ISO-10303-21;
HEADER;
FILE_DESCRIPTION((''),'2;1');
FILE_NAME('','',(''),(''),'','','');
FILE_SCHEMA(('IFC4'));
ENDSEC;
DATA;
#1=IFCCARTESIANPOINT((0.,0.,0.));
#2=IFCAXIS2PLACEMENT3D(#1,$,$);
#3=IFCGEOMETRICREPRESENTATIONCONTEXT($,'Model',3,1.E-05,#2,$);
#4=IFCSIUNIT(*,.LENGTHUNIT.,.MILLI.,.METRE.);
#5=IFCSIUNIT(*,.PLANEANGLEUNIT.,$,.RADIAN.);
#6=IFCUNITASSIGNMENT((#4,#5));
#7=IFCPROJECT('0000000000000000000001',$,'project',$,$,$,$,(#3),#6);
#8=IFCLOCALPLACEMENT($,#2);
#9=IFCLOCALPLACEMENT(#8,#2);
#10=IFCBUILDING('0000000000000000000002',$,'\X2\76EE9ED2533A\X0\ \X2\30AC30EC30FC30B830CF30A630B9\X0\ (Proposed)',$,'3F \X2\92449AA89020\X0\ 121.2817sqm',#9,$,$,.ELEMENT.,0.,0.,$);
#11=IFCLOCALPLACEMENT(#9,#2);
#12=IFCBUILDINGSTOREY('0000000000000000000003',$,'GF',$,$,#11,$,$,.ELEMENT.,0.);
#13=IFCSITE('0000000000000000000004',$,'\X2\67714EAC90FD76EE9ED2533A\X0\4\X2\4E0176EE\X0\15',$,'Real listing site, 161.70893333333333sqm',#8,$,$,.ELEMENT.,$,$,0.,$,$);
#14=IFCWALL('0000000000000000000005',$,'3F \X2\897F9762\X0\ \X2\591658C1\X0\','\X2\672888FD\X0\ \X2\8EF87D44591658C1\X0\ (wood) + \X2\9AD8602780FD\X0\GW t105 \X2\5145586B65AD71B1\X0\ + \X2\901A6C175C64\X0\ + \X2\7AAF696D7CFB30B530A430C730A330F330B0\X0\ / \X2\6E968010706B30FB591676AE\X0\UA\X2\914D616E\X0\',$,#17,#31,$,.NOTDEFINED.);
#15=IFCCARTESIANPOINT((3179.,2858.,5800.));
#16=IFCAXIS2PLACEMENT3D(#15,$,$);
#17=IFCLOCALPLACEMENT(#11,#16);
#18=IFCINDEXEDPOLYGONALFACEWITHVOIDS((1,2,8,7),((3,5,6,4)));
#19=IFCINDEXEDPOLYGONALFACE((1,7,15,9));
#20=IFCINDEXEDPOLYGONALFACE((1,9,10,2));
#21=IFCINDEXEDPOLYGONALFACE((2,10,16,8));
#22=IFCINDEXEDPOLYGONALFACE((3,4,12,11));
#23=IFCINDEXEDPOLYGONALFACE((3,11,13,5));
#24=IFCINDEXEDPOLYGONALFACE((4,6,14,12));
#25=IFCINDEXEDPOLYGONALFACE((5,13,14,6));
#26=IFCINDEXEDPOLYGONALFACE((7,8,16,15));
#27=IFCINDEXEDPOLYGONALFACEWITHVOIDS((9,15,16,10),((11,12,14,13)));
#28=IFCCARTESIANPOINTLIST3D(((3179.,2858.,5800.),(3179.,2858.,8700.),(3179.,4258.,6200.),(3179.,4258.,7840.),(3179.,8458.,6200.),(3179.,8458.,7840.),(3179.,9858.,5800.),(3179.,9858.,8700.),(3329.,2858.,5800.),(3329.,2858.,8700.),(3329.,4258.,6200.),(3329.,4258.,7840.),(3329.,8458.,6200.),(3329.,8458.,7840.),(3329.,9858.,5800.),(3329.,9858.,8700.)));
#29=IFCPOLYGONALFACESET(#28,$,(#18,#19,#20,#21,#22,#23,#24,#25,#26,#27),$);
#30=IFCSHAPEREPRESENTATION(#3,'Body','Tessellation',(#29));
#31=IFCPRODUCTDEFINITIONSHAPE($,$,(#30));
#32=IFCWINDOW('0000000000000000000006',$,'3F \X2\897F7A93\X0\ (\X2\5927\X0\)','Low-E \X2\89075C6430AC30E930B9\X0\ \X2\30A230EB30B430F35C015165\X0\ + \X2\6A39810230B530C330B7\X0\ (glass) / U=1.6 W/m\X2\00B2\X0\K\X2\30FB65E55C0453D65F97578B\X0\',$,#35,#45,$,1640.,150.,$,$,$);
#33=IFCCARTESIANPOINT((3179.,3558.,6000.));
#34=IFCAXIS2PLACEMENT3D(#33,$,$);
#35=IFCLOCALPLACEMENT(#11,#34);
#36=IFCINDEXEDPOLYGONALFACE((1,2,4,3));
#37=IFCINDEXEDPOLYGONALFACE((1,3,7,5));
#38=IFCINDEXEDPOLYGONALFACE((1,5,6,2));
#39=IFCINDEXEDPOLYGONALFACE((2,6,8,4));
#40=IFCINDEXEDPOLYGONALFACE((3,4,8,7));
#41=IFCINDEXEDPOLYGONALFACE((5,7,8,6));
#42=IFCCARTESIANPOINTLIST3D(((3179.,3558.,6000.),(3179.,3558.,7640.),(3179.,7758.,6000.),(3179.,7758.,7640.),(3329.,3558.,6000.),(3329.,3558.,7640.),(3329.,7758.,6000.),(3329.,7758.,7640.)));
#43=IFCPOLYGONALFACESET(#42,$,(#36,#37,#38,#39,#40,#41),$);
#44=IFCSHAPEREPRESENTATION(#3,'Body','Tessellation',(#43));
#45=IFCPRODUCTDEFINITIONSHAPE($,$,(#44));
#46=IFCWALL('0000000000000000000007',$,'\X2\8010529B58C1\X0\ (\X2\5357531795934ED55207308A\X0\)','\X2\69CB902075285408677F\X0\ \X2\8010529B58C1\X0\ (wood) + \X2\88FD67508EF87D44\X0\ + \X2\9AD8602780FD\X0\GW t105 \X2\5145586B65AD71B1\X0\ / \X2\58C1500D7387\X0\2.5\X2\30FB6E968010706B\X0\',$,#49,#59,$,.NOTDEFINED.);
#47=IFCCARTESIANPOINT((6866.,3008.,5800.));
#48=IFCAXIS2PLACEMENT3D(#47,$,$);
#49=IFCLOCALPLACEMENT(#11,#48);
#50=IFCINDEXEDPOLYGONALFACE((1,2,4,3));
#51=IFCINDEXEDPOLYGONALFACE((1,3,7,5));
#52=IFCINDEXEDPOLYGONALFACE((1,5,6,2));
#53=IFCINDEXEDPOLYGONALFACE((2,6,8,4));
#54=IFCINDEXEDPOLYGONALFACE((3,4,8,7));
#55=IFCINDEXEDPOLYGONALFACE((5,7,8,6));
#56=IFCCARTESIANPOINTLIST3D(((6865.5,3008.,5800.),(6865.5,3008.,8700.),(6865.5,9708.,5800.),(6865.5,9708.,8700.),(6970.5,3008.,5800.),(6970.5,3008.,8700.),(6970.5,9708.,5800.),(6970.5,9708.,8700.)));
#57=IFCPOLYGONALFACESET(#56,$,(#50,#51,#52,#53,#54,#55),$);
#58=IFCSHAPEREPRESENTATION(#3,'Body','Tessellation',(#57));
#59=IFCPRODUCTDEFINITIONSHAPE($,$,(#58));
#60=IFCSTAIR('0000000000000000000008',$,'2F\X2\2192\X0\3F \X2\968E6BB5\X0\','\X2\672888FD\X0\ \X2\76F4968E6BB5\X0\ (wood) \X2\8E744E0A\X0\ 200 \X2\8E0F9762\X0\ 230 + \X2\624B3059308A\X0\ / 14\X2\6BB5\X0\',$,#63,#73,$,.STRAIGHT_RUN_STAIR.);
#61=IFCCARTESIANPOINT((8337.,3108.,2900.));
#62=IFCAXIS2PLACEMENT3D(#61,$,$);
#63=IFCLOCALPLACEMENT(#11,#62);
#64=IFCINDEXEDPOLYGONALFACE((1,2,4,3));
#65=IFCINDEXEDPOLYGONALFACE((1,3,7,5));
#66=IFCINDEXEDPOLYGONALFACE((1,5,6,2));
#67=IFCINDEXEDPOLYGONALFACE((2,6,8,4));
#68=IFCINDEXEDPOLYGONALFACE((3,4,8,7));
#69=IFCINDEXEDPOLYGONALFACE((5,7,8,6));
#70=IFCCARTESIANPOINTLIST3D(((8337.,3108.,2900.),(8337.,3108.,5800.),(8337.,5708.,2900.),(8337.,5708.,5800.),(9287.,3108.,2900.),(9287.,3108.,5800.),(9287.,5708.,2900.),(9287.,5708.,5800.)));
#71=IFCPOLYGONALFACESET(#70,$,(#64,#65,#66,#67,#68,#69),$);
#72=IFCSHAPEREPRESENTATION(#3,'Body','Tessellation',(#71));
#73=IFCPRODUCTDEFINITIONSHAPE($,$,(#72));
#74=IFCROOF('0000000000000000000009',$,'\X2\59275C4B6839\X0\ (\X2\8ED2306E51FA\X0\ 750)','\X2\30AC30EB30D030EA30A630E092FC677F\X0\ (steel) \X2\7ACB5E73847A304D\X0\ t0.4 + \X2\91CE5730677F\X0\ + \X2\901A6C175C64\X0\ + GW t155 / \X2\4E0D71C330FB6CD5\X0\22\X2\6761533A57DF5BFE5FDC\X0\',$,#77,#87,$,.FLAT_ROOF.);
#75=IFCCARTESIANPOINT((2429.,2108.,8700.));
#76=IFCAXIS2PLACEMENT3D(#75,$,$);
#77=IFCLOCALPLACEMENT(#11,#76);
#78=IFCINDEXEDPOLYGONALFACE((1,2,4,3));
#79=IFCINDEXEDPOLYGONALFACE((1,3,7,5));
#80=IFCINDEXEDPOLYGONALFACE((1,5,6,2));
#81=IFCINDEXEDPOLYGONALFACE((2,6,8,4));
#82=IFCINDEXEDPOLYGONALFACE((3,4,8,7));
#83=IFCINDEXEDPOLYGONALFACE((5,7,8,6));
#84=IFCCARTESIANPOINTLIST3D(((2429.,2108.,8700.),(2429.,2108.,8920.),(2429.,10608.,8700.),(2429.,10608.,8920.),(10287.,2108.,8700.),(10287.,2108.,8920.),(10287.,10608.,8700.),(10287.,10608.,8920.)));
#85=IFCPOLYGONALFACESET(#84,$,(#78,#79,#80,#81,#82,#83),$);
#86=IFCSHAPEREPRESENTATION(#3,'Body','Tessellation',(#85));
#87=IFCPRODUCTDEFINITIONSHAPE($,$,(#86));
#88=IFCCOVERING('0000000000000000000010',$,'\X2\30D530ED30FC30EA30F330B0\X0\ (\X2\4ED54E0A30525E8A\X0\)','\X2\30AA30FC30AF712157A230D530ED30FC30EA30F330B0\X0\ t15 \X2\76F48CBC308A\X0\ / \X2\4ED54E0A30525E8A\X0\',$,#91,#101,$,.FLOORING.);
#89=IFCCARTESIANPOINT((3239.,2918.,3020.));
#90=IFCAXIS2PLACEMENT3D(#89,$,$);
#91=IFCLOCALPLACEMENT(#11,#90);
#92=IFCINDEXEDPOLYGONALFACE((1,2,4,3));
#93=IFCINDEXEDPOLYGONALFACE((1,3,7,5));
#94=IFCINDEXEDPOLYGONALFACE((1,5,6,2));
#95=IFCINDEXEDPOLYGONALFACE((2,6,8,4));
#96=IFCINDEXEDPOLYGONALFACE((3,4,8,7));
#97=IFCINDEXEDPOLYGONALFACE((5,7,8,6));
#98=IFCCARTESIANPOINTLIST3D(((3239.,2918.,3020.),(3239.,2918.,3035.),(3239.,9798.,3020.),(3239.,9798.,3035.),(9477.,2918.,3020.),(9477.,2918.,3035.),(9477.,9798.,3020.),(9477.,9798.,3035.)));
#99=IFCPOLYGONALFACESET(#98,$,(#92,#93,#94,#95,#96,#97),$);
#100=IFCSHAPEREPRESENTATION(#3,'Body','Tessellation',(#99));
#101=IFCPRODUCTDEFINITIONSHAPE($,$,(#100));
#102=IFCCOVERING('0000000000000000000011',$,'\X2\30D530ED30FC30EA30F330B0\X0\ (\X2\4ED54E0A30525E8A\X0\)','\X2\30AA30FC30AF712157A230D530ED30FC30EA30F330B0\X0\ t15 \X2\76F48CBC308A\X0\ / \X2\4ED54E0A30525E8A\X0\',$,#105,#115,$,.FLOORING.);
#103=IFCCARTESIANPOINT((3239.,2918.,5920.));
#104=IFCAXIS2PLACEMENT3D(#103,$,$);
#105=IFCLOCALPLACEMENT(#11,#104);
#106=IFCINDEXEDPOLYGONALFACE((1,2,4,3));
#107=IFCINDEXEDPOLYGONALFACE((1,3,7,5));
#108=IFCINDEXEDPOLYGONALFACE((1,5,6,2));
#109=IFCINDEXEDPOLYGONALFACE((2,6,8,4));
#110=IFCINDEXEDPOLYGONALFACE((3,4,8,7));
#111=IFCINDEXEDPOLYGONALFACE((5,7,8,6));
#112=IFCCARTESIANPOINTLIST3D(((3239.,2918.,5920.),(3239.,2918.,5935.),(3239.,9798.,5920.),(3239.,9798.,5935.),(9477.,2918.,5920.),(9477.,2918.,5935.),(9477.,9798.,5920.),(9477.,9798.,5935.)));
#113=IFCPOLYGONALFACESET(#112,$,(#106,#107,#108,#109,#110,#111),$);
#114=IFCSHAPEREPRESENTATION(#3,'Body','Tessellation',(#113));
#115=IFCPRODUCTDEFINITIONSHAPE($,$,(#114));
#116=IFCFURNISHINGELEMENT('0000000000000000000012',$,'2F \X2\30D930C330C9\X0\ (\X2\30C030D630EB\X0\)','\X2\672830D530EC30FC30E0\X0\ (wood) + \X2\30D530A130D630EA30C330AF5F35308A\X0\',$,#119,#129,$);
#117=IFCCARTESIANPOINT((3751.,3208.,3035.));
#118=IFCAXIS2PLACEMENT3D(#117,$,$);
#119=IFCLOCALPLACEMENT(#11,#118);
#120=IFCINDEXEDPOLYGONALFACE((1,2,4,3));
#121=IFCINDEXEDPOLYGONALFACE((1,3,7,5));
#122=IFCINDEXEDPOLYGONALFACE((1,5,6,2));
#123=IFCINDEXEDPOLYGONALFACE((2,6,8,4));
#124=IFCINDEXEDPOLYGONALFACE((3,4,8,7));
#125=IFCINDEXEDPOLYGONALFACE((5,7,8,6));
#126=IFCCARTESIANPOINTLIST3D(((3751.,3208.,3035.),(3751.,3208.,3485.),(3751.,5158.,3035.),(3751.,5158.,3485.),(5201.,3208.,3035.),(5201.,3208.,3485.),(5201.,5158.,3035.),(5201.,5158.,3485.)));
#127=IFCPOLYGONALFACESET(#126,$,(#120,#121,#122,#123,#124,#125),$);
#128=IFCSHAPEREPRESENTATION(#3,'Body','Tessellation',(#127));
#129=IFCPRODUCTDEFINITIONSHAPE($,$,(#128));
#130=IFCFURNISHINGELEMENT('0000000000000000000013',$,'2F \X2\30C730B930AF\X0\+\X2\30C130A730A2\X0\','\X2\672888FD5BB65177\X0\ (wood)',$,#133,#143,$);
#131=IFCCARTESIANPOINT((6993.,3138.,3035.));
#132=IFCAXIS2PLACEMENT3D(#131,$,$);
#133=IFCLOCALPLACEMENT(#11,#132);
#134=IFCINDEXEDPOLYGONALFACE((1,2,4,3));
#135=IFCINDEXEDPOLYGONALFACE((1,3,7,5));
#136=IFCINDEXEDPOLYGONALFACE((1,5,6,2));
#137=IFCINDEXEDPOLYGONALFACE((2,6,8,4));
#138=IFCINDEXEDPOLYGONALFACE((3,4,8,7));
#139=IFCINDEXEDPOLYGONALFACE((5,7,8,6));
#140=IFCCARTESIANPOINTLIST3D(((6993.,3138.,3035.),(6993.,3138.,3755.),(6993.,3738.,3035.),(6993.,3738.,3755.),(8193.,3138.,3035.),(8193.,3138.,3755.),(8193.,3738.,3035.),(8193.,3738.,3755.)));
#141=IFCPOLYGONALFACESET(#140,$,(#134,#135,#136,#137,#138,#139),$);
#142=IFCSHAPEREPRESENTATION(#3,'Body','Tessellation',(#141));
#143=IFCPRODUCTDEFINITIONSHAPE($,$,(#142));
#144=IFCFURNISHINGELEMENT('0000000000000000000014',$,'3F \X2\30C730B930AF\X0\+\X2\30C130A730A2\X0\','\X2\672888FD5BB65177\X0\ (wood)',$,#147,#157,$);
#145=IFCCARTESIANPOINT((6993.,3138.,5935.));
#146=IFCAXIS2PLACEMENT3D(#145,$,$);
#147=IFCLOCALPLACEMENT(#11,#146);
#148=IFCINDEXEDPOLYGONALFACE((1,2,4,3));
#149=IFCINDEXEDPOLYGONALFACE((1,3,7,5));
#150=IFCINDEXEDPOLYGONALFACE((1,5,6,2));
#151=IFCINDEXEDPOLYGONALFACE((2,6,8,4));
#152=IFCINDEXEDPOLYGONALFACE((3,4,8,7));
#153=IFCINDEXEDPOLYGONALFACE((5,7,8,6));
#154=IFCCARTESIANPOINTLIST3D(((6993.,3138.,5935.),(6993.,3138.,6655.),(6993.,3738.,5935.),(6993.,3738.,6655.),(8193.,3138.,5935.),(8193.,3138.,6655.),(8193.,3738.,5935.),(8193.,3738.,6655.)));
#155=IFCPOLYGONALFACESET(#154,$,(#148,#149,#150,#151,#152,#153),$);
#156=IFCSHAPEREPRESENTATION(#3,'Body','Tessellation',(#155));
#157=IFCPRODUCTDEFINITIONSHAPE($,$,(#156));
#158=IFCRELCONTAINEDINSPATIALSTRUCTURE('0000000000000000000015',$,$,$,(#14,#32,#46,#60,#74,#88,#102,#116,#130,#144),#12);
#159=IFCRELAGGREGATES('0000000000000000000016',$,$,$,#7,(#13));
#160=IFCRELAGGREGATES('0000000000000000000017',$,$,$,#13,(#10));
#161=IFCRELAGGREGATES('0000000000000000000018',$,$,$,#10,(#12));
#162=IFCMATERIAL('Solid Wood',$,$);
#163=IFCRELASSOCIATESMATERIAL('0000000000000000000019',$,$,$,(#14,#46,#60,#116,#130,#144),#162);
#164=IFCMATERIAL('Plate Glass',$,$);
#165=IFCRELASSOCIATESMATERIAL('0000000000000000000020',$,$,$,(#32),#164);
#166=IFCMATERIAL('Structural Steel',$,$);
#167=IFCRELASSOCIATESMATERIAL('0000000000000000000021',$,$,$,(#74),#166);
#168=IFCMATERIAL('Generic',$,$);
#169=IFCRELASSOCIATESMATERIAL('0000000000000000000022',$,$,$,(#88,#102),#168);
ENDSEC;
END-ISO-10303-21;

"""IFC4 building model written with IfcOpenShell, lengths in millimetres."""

from ifc_helpers import new_model, si_unit, frame, frame_2d, origin, place, context, project, spatial, rectangle, extrude, material, element, fill, save


model = new_model("IFC4")

# Units and contexts
model_context = context("Model", 3, precision=1e-05, world=origin())
ifc_project = project(units=[si_unit("LENGTHUNIT", "METRE", prefix="MILLI"), si_unit("PLANEANGLEUNIT", "RADIAN")], contexts=[model_context])

# Site, building, storey
site_placement = place(None, origin())
site = spatial("IfcSite", under=ifc_project, at=site_placement, Name="東京都目黒区4丁目15", ObjectType="Real listing site, 161.70893333333333sqm", CompositionType="ELEMENT", RefElevation=0.0)
building_placement = place(site_placement, origin())
building = spatial("IfcBuilding", under=site, at=building_placement, Name="目黒区 ガレージハウス (Proposed)", ObjectType="3F 鉄骨造 121.2817sqm", CompositionType="ELEMENT", ElevationOfRefHeight=0.0, ElevationOfTerrain=0.0)
storey_placement = place(building_placement, origin())
storey = spatial("IfcBuildingStorey", under=building, at=storey_placement, Name="GF", CompositionType="ELEMENT", Elevation=0.0)

# Shared definitions
ifc_material_1 = material(Name="Solid Wood")

# Shared definitions
ifc_material_2 = material(Name="Plate Glass")

# Wall, opening, window
wall_1_placement = place(storey_placement, frame((3179.0, 2858.0, 5800.0)))
wall_1 = element("IfcWall", 1, at=wall_1_placement, inside=storey, material=ifc_material_1, Name="3F 西面 外壁", Description="木製 軸組外壁 (wood) + 高性能GW t105 充填断熱 + 通気層 + 窯業系サイディング / 準耐火・外皮UA配慮", PredefinedType="NOTDEFINED", context=model_context, shape_type="SweptSolid", body=[
    extrude(rectangle(XDim=150.0, YDim=7000.0, at=frame_2d((75.0, 3500.0))), frame((3179.0, 2858.0, 5800.0)), (0.0, 0.0, 1.0), 2900.0),
])
opening_1_placement = place(storey_placement, frame((3179.0, 3558.0, 6000.0)))
opening_1 = element("IfcOpeningElement", 2, at=opening_1_placement, cuts=wall_1, PredefinedType="NOTDEFINED", context=model_context, shape_type="SweptSolid", body=[
    extrude(rectangle(XDim=150.0, YDim=4200.0, at=frame_2d((75.0, 2100.0))), frame((3179.0, 3558.0, 6000.0)), (0.0, 0.0, 1.0), 1640.0),
])
window_1_placement = place(storey_placement, frame((3179.0, 3558.0, 6000.0)))
window_1 = element("IfcWindow", 3, at=window_1_placement, inside=storey, material=ifc_material_2, Name="3F 西窓 (大)", Description="Low-E 複層ガラス アルゴン封入 + 樹脂サッシ (glass) / U=1.6 W/m²K・日射取得型", OverallHeight=1640.0, OverallWidth=150.0, context=model_context, shape_type="SweptSolid", body=[
    extrude(rectangle(XDim=150.0, YDim=4200.0, at=frame_2d((75.0, 2100.0))), frame((3179.0, 3558.0, 6000.0)), (0.0, 0.0, 1.0), 1640.0),
])
fill(opening_1, window_1)

# Wall
wall_2_placement = place(storey_placement, frame((6866.0, 3008.0, 5800.0)))
element("IfcWall", 4, at=wall_2_placement, inside=storey, material=ifc_material_1, Name="耐力壁 (南北間仕切り)", Description="構造用合板 耐力壁 (wood) + 製材軸組 + 高性能GW t105 充填断熱 / 壁倍率2.5・準耐火", PredefinedType="NOTDEFINED", context=model_context, shape_type="SweptSolid", body=[
    extrude(rectangle(XDim=105.0, YDim=6700.0, at=frame_2d((52.0, 3350.0))), frame((6866.0, 3008.0, 5800.0)), (0.0, 0.0, 1.0), 2900.0),
])

# Stair
stair_placement = place(storey_placement, frame((8337.0, 3108.0, 2900.0)))
element("IfcStair", 5, at=stair_placement, inside=storey, material=ifc_material_1, Name="2F→3F 階段", Description="木製 直階段 (wood) 蹴上 200 踏面 230 + 手すり / 14段", PredefinedType="STRAIGHT_RUN_STAIR", context=model_context, shape_type="SweptSolid", body=[
    extrude(rectangle(XDim=950.0, YDim=2600.0, at=frame_2d((475.0, 1300.0))), frame((8337.0, 3108.0, 2900.0)), (0.0, 0.0, 1.0), 2900.0),
])

# Roof
ifc_material_3 = material(Name="Structural Steel")
roof_placement = place(storey_placement, frame((2429.0, 2108.0, 8700.0)))
element("IfcRoof", 6, at=roof_placement, inside=storey, material=ifc_material_3, Name="大屋根 (軒の出 750)", Description="ガルバリウム鋼板 (steel) 立平葺き t0.4 + 野地板 + 通気層 + GW t155 / 不燃・法22条区域対応", PredefinedType="FLAT_ROOF", context=model_context, shape_type="SweptSolid", body=[
    extrude(rectangle(XDim=7858.0, YDim=8500.0, at=frame_2d((3929.0, 4250.0))), frame((2429.0, 2108.0, 8700.0)), (0.0, 0.0, 1.0), 220.0),
])

# Coverings
ifc_material_4 = material(Name="Generic")
covering_1_placement = place(storey_placement, frame((3239.0, 2918.0, 3020.0)))
element("IfcCovering", 7, at=covering_1_placement, inside=storey, material=ifc_material_4, Name="フローリング (仕上げ床)", Description="オーク無垢フローリング t15 直貼り / 仕上げ床", PredefinedType="FLOORING", context=model_context, shape_type="SweptSolid", body=[
    extrude(rectangle(XDim=6238.0, YDim=6880.0, at=frame_2d((3119.0, 3440.0))), frame((3239.0, 2918.0, 3020.0)), (0.0, 0.0, 1.0), 15.0),
])
covering_2_placement = place(storey_placement, frame((3239.0, 2918.0, 5920.0)))
element("IfcCovering", 8, at=covering_2_placement, inside=storey, material=ifc_material_4, Name="フローリング (仕上げ床)", Description="オーク無垢フローリング t15 直貼り / 仕上げ床", PredefinedType="FLOORING", context=model_context, shape_type="SweptSolid", body=[
    extrude(rectangle(XDim=6238.0, YDim=6880.0, at=frame_2d((3119.0, 3440.0))), frame((3239.0, 2918.0, 5920.0)), (0.0, 0.0, 1.0), 15.0),
])

# Furnishing elements
furnishing_1_placement = place(storey_placement, frame((3751.0, 3208.0, 3035.0)))
element("IfcFurnishingElement", 9, at=furnishing_1_placement, inside=storey, material=ifc_material_1, Name="2F ベッド (ダブル)", Description="木フレーム (wood) + ファブリック張り", context=model_context, shape_type="SweptSolid", body=[
    extrude(rectangle(XDim=1450.0, YDim=1950.0, at=frame_2d((725.0, 975.0))), frame((3751.0, 3208.0, 3035.0)), (0.0, 0.0, 1.0), 450.0),
])
furnishing_2_placement = place(storey_placement, frame((6993.0, 3138.0, 3035.0)))
element("IfcFurnishingElement", 10, at=furnishing_2_placement, inside=storey, material=ifc_material_1, Name="2F デスク+チェア", Description="木製家具 (wood)", context=model_context, shape_type="SweptSolid", body=[
    extrude(rectangle(XDim=1200.0, YDim=600.0, at=frame_2d((600.0, 300.0))), frame((6993.0, 3138.0, 3035.0)), (0.0, 0.0, 1.0), 720.0),
])
furnishing_3_placement = place(storey_placement, frame((6993.0, 3138.0, 5935.0)))
element("IfcFurnishingElement", 11, at=furnishing_3_placement, inside=storey, material=ifc_material_1, Name="3F デスク+チェア", Description="木製家具 (wood)", context=model_context, shape_type="SweptSolid", body=[
    extrude(rectangle(XDim=1200.0, YDim=600.0, at=frame_2d((600.0, 300.0))), frame((6993.0, 3138.0, 5935.0)), (0.0, 0.0, 1.0), 720.0),
])

save(model, "model.ifc")
